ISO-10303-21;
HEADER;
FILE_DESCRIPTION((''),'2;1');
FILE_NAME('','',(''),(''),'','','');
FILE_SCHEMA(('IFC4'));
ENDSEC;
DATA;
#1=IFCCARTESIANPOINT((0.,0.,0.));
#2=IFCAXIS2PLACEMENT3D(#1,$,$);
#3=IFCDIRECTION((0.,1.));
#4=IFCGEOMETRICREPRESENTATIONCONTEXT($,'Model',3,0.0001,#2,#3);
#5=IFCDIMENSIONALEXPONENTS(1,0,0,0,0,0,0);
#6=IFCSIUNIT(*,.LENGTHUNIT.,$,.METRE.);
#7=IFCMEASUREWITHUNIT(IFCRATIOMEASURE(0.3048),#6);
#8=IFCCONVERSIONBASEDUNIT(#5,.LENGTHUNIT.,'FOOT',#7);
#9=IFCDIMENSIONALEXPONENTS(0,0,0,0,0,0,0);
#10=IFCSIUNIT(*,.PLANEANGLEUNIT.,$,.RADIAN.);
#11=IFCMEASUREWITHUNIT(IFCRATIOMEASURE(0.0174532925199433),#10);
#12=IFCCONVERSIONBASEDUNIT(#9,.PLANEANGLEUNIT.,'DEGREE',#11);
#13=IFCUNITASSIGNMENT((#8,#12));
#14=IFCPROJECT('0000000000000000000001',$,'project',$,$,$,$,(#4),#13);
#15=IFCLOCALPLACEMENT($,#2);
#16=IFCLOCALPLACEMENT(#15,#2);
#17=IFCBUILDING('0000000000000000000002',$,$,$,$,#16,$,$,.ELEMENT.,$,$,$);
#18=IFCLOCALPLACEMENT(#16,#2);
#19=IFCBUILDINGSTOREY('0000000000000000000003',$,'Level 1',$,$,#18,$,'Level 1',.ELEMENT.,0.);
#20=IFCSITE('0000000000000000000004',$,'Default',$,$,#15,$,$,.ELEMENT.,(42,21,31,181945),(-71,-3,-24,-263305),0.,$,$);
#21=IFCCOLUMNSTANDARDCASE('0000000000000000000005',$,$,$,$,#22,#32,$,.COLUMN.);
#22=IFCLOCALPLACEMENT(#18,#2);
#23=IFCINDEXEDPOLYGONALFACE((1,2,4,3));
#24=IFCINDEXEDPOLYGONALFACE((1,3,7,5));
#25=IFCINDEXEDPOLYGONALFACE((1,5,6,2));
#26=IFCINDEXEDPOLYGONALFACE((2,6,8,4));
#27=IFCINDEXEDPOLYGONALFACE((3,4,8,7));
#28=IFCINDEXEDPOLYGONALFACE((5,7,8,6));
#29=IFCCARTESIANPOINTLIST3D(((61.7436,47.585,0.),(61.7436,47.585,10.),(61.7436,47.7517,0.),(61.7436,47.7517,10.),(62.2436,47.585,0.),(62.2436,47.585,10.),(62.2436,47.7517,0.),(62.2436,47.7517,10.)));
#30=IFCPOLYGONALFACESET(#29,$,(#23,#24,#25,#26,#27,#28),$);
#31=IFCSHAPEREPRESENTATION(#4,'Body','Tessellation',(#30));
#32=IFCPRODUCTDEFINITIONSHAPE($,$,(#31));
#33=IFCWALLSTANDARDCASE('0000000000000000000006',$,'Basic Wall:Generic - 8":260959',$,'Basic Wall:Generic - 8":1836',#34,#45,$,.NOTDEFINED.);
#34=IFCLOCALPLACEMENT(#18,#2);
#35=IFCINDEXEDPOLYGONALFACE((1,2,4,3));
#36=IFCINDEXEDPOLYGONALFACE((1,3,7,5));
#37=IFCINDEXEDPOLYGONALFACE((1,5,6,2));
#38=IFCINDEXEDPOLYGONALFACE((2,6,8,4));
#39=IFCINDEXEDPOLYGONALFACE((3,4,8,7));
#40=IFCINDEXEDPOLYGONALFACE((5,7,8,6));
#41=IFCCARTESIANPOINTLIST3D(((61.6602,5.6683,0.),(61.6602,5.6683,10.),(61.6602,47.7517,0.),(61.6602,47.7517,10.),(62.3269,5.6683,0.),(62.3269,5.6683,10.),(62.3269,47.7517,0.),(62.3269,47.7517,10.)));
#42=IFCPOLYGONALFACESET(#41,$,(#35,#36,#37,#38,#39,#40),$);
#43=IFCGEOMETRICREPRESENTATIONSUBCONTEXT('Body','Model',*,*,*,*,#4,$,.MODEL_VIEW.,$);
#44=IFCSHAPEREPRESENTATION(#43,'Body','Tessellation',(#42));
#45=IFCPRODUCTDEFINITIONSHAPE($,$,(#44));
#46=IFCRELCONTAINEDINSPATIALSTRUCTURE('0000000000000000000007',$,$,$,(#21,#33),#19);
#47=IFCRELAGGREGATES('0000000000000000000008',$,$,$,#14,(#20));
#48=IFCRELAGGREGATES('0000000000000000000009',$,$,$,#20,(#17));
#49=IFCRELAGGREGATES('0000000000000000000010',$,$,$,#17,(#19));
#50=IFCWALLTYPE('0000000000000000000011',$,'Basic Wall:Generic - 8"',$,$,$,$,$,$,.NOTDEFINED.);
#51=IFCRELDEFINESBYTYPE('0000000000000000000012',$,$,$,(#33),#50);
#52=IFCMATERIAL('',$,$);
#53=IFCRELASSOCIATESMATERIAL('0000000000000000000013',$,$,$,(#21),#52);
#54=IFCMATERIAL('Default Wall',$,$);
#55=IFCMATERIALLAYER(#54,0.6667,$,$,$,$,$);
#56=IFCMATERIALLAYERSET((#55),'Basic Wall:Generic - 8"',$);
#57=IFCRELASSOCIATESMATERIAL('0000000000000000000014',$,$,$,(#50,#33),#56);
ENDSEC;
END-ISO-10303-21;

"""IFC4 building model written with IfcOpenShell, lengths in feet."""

from ifc_helpers import new_model, entity, si_unit, converted_unit, direction, frame, frame_2d, origin, place, context, subcontext, project, spatial, rectangle, extrude, material, layer, layer_set, layer_usage, type_object, element, save


model = new_model("IFC4")

# Units and contexts
model_context = context("Model", 3, precision=0.0001, world=origin(), true_north=direction((0.0, 1.0)))
body_context = subcontext(model_context, "Body", "Model", "MODEL_VIEW")
ifc_project = project(units=[converted_unit("LENGTHUNIT", "FOOT", entity("IfcRatioMeasure", 0.3048), si_unit("LENGTHUNIT", "METRE"), dimensions=[1, 0, 0, 0, 0, 0, 0]), converted_unit("PLANEANGLEUNIT", "DEGREE", entity("IfcRatioMeasure", 0.0174532925199433), si_unit("PLANEANGLEUNIT", "RADIAN"), dimensions=[0, 0, 0, 0, 0, 0, 0])], contexts=[model_context])

# Site, building, storey
site_placement = place(None, origin())
site = spatial("IfcSite", under=ifc_project, at=site_placement, Name="Default", CompositionType="ELEMENT", RefLatitude=(42, 21, 31, 181945), RefLongitude=(-71, -3, -24, -263305), RefElevation=0.0)
building_placement = place(site_placement, origin())
building = spatial("IfcBuilding", under=site, at=building_placement, CompositionType="ELEMENT")
storey_placement = place(building_placement, origin())
storey = spatial("IfcBuildingStorey", under=building, at=storey_placement, Name="Level 1", LongName="Level 1", CompositionType="ELEMENT", Elevation=0.0)

# Column
ifc_material_1 = material(Name="")
wall_placement = place(storey_placement, frame((61.9936, 47.7517, 0.0), z_axis=(0.0, 0.0, 1.0), x_axis=(0.0, -1.0, 0.0)))
for number, where, z_axis, x_axis in (
    (1, (0.0833, 0.0, 0.0), (0.0, 0.0, 1.0), (1.0, 0.0, 0.0)),
):
    element("IfcColumnStandardCase", number, at=place(wall_placement, frame(where, z_axis=z_axis, x_axis=x_axis)), inside=storey, material=ifc_material_1, PredefinedType="COLUMN", context=model_context, shape_type="SweptSolid", body=[
        extrude(rectangle(XDim=0.1667, YDim=0.5), origin(), (0.0, 0.0, 1.0), 10.0),
    ])

# Wall
ifc_material_2 = material(Name="Default Wall")
ifc_layer = layer(ifc_material_2, 0.6667)
ifc_layer_set = layer_set([ifc_layer], Name="Basic Wall:Generic - 8\"")
ifc_layer_usage = layer_usage(ifc_layer_set, "AXIS2", "NEGATIVE", 0.3333)
wall_type = type_object("IfcWallType", Name="Basic Wall:Generic - 8\"", PredefinedType="NOTDEFINED", material=ifc_layer_set)
element("IfcWallStandardCase", 2, at=wall_placement, inside=storey, type_object=wall_type, material=ifc_layer_usage, Name="Basic Wall:Generic - 8\":260959", ObjectType="Basic Wall:Generic - 8\":1836", PredefinedType="NOTDEFINED", context=body_context, shape_type="SweptSolid", body=[
    extrude(rectangle(XDim=42.0834, YDim=0.6667, at=frame_2d((21.0417, 0.0), x_axis=(-1.0, 0.0))), origin(), (0.0, 0.0, 1.0), 10.0),
])

save(model, "model.ifc")
